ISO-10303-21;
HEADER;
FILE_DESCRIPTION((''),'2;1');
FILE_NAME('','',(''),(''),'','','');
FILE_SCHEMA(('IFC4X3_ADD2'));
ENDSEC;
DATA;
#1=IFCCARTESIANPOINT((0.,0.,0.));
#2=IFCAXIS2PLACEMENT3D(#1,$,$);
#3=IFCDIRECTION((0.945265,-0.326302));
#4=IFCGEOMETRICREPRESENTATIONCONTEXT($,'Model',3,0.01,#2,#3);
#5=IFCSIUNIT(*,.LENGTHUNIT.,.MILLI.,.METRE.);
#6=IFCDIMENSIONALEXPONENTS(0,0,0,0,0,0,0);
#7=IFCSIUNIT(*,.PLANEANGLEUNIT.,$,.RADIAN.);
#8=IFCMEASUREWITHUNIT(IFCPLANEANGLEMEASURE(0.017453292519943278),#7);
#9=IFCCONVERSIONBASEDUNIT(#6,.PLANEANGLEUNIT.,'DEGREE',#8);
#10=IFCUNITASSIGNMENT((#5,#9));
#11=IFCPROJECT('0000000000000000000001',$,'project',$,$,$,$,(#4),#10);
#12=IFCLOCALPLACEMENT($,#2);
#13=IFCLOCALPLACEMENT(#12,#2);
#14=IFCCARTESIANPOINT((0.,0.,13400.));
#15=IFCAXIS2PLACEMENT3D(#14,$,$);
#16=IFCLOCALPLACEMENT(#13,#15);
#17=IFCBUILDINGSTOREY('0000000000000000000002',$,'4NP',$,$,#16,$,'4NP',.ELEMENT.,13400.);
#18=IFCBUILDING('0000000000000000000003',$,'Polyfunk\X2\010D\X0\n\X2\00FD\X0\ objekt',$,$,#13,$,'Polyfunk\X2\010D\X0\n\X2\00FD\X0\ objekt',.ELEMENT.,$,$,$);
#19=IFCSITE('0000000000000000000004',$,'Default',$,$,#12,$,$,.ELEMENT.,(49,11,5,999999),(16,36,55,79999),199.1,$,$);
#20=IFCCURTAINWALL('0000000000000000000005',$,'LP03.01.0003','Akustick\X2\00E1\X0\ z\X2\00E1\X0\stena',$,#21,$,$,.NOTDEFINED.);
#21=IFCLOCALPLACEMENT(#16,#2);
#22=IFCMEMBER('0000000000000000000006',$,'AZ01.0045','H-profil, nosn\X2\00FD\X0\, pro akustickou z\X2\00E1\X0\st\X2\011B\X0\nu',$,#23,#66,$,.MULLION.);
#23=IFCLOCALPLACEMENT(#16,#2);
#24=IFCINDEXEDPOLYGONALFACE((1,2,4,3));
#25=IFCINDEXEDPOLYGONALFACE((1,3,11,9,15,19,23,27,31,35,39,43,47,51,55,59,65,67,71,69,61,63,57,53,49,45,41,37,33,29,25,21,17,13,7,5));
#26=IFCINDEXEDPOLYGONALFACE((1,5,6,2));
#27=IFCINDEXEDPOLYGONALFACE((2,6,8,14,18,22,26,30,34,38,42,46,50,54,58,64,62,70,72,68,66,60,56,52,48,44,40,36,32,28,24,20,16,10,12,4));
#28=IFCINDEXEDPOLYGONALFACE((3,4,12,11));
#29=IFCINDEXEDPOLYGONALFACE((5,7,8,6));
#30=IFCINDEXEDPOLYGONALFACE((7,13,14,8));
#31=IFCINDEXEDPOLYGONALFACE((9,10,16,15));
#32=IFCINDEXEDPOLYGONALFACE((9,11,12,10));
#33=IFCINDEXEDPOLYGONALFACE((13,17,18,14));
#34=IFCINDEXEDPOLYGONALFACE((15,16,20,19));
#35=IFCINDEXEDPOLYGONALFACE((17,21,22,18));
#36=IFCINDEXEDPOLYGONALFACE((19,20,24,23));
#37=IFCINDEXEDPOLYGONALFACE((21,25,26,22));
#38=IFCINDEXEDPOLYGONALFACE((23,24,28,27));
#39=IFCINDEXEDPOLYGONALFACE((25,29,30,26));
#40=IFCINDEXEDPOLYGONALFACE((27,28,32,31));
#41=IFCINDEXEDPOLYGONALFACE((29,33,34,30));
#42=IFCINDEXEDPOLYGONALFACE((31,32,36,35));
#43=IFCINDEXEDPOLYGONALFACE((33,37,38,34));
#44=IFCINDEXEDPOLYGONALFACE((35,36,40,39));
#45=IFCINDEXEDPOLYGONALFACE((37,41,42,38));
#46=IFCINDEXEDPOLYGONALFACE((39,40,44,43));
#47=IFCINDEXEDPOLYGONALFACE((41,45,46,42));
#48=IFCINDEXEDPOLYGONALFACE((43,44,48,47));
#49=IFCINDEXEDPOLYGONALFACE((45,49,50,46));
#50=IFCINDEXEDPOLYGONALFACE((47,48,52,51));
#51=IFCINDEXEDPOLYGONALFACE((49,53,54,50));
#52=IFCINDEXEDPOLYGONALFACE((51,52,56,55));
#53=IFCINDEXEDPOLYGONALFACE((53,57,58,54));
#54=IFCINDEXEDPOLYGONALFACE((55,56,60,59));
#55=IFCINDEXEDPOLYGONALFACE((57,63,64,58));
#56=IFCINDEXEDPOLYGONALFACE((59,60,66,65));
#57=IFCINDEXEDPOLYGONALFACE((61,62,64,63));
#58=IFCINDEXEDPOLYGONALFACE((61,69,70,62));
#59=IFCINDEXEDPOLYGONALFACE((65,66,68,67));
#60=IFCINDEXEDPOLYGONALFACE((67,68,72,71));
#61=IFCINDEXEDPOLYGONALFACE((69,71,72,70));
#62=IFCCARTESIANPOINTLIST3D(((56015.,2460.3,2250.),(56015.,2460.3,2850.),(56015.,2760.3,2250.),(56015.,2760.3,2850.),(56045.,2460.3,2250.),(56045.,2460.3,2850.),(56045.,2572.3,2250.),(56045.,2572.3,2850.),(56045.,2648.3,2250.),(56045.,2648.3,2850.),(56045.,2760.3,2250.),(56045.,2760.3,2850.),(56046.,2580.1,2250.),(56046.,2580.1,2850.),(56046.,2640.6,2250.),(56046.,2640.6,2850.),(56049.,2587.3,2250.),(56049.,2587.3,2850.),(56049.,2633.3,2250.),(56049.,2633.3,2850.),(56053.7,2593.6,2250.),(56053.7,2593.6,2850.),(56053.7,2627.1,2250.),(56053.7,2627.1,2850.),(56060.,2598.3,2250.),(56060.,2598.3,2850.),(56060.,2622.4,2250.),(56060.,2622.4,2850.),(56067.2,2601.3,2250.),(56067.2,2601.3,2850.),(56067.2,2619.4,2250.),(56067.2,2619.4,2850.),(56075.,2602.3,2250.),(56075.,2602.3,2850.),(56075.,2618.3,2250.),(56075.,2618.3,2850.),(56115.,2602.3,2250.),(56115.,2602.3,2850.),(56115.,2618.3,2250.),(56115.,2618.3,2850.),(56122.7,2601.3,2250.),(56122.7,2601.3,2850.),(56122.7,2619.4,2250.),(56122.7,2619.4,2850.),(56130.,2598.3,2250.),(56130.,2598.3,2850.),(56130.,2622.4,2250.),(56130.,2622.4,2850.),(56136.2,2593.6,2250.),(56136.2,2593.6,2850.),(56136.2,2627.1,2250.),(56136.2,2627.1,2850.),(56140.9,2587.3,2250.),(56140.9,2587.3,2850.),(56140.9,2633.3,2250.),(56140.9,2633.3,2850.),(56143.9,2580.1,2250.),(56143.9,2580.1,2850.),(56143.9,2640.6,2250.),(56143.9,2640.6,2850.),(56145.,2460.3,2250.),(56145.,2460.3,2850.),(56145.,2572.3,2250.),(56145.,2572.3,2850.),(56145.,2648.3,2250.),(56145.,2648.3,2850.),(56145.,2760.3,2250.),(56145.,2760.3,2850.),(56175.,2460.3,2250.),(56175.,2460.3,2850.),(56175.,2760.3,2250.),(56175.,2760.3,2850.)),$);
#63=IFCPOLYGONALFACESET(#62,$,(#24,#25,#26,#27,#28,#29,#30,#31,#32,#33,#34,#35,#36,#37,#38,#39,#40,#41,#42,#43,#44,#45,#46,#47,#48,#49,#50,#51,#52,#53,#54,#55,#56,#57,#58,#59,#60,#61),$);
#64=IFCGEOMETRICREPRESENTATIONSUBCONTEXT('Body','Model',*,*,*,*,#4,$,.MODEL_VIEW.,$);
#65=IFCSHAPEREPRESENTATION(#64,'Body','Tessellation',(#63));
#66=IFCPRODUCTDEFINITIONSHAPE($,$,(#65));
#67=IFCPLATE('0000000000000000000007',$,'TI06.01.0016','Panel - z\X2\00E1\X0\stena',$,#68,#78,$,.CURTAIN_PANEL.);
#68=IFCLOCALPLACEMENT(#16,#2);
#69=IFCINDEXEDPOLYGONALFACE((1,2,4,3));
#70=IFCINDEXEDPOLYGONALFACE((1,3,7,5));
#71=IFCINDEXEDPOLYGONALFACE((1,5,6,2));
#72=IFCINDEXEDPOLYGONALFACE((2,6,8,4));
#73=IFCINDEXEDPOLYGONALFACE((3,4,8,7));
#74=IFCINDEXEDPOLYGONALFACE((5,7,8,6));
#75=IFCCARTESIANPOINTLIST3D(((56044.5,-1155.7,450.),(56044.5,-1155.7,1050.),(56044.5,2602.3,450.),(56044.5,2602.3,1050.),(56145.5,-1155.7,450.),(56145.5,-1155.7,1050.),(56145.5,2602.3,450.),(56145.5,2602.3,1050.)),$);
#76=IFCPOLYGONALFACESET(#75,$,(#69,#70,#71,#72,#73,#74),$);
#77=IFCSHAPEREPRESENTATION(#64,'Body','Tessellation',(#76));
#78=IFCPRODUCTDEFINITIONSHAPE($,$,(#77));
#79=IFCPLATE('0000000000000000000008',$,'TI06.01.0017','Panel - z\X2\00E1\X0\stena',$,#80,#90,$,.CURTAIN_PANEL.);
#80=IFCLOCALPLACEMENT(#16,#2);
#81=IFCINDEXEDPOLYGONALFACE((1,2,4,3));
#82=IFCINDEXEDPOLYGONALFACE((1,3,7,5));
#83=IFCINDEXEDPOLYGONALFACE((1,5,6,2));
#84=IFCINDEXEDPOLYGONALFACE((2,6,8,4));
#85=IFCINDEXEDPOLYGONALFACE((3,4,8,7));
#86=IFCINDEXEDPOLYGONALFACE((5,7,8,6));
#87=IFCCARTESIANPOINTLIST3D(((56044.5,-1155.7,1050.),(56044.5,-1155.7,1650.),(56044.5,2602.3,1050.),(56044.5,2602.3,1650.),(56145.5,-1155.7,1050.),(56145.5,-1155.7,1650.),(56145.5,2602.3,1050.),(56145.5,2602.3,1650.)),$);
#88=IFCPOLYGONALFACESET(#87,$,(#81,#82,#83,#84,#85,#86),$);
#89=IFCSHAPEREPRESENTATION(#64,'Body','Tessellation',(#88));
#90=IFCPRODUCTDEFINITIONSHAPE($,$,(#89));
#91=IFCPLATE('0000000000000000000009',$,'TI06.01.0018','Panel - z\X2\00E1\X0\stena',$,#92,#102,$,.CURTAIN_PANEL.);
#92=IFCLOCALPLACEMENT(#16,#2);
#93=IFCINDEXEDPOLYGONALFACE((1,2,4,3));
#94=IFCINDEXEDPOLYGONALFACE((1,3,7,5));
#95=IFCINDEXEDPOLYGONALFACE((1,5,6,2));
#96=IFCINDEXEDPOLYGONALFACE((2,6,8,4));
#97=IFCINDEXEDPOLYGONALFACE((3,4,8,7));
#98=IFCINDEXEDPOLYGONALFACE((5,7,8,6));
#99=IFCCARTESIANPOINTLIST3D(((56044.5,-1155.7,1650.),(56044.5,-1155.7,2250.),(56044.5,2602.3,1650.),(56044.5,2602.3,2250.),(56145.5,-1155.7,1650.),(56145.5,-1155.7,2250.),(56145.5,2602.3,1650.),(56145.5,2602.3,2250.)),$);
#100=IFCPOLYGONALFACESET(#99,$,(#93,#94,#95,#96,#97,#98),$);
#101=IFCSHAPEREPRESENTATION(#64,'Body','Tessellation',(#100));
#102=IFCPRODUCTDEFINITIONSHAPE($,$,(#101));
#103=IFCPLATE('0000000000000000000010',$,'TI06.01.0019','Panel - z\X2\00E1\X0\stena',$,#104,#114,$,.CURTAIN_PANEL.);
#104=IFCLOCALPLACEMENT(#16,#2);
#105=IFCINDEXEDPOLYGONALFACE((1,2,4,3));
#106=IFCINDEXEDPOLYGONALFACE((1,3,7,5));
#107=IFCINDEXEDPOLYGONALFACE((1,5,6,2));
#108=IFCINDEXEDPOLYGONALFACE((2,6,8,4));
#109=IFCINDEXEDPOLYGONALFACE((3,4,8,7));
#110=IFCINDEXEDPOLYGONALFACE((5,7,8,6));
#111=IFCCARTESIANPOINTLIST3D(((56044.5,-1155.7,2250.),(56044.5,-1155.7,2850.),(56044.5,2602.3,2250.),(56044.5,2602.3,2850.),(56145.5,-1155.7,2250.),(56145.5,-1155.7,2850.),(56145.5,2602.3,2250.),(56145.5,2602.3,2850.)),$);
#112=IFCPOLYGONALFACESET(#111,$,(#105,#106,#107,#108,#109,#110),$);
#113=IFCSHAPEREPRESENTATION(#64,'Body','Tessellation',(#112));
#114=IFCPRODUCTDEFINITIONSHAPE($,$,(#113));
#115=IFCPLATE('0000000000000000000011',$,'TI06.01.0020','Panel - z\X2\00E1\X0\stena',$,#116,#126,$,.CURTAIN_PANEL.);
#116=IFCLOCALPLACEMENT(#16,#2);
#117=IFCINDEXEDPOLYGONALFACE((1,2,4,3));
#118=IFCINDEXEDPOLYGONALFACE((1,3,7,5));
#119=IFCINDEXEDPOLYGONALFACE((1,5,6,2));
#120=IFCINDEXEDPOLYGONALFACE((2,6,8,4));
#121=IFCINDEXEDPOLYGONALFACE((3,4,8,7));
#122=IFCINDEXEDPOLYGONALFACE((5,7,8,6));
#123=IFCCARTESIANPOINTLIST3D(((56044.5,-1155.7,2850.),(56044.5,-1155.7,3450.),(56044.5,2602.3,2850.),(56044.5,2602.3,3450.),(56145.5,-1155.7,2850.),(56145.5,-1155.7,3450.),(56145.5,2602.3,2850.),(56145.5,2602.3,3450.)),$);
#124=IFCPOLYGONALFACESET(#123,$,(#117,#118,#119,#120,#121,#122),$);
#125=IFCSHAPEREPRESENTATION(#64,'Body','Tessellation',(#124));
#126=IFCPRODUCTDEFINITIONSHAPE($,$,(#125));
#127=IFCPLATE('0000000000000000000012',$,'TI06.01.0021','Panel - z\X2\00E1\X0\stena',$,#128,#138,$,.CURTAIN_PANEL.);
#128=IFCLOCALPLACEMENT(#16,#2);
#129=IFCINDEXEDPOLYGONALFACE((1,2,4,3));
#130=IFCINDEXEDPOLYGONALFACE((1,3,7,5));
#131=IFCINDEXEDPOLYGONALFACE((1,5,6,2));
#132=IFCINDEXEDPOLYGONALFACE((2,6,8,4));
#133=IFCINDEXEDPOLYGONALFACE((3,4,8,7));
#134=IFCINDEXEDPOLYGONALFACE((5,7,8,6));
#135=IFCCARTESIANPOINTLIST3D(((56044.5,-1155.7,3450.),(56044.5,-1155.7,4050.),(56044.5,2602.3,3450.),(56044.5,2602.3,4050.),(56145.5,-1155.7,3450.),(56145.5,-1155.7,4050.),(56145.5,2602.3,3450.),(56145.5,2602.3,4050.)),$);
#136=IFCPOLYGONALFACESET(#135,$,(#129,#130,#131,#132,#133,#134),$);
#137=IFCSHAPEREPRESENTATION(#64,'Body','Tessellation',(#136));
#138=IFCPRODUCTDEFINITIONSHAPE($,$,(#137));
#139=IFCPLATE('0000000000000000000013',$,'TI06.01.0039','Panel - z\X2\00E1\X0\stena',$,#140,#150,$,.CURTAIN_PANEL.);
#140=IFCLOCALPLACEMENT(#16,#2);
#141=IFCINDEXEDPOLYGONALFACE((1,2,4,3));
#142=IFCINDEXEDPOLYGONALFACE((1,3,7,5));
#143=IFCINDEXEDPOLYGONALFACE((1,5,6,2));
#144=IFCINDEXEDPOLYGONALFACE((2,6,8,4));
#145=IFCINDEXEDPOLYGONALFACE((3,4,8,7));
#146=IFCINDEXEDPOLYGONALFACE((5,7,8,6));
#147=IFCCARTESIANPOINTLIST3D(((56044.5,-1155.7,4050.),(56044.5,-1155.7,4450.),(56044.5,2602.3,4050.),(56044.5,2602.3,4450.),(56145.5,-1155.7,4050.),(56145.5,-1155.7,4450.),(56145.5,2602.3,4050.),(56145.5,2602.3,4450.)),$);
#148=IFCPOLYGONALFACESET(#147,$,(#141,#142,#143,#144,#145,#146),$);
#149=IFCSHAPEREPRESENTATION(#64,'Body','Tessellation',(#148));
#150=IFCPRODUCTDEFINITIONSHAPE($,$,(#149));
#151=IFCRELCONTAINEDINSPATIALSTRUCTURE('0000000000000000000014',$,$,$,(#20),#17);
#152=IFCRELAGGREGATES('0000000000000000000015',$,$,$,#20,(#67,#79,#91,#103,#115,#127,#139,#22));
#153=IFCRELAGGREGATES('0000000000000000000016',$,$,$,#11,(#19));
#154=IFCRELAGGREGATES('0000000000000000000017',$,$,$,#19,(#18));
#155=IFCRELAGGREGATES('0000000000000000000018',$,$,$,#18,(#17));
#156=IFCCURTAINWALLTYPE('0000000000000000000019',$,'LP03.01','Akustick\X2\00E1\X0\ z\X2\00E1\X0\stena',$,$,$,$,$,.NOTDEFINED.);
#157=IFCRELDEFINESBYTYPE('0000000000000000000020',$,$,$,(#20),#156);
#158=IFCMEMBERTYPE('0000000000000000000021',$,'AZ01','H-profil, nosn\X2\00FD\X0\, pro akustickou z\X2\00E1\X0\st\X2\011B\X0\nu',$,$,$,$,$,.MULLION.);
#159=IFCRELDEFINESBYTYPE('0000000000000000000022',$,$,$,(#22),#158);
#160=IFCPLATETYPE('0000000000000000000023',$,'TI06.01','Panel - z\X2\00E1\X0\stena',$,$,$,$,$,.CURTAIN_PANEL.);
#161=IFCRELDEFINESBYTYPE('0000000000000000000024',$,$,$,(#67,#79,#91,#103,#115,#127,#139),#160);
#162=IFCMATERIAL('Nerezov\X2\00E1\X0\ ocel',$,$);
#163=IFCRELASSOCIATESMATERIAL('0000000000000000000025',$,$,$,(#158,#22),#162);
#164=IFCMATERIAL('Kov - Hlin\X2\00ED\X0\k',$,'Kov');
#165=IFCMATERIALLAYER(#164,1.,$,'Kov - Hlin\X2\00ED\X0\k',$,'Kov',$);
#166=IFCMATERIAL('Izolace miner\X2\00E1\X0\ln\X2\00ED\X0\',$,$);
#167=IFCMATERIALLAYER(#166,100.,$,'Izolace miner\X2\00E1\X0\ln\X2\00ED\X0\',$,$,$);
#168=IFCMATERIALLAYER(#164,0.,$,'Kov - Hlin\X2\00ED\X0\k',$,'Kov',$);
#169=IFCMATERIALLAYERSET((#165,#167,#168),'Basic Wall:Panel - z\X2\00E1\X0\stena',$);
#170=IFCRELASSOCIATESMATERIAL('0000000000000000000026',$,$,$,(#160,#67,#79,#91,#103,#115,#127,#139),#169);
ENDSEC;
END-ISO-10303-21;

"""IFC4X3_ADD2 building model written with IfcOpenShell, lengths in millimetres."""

from ifc_helpers import new_model, entity, si_unit, converted_unit, direction, frame, frame_2d, origin, place, context, subcontext, project, spatial, polyline, circle_curve, parameter, trimmed, segment, composite_curve, rectangle, outline, extrude, source, transform, mapped, material, layer, layer_set, layer_usage, material_profile, profile_set, profile_usage, type_object, element, aggregate, save


model = new_model("IFC4X3_ADD2")

# Units and contexts
model_context = context("Model", 3, precision=0.01, world=origin(), true_north=direction((0.945265, -0.326302)))
body_context = subcontext(model_context, "Body", "Model", "MODEL_VIEW")
ifc_project = project(units=[si_unit("LENGTHUNIT", "METRE", prefix="MILLI"), converted_unit("PLANEANGLEUNIT", "DEGREE", entity("IfcPlaneAngleMeasure", 0.017453292519943278), si_unit("PLANEANGLEUNIT", "RADIAN"), dimensions=[0, 0, 0, 0, 0, 0, 0])], contexts=[model_context])

# Site, building, storey
site_placement = place(None, origin())
site = spatial("IfcSite", under=ifc_project, at=site_placement, Name="Default", CompositionType="ELEMENT", RefLatitude=(49, 11, 5, 999999), RefLongitude=(16, 36, 55, 79999), RefElevation=199.1)
building_placement = place(site_placement, origin())
building = spatial("IfcBuilding", under=site, at=building_placement, Name="Polyfunkčný objekt", LongName="Polyfunkčný objekt", CompositionType="ELEMENT")
storey_placement = place(building_placement, frame((0.0, 0.0, 13400.0)))
storey = spatial("IfcBuildingStorey", under=building, at=storey_placement, Name="4NP", LongName="4NP", CompositionType="ELEMENT", Elevation=13400.0)

# Curtain wall, member, plates
curtain_wall_type = type_object("IfcCurtainWallType", Name="LP03.01", Description="Akustická zástena", PredefinedType="NOTDEFINED")
curtain_wall_placement = place(storey_placement, frame((0.0, 0.0, -13400.0)))
curtain_wall = element("IfcCurtainWall", 1, at=curtain_wall_placement, inside=storey, type_object=curtain_wall_type, Name="LP03.01.0003", Description="Akustická zástena", PredefinedType="NOTDEFINED")
ifc_material_1 = material(Name="Nerezová ocel")
ifc_material_profile = material_profile(ifc_material_1, outline(composite_curve([segment(polyline([(50.0, -150.0), (80.0, -150.0)]), True, "CONTINUOUS"), segment(polyline([(80.0, -150.0), (80.0, 150.0)]), True, "CONTINUOUS"), segment(polyline([(80.0, 150.0), (50.0, 150.0)]), True, "CONTINUOUS"), segment(polyline([(50.0, 150.0), (50.0, 38.0)]), True, "CONTINUOUS"), segment(trimmed(circle_curve(frame_2d((20.0, 38.0), x_axis=(0.0, 1.0)), 30.0), [parameter(180.0)], [parameter(270.0)], True, "PARAMETER"), False, "CONTINUOUS"), segment(polyline([(20.0, 8.0), (-20.0, 8.0)]), True, "CONTINUOUS"), segment(trimmed(circle_curve(frame_2d((-20.0, 38.0), x_axis=(0.0, 1.0)), 30.0), [parameter(90.0)], [parameter(180.0)], True, "PARAMETER"), False, "CONTINUOUS"), segment(polyline([(-50.0, 38.0), (-50.0, 150.0)]), True, "CONTINUOUS"), segment(polyline([(-50.0, 150.0), (-80.0, 150.0)]), True, "CONTINUOUS"), segment(polyline([(-80.0, 150.0), (-80.0, -150.0)]), True, "CONTINUOUS"), segment(polyline([(-80.0, -150.0), (-50.0, -150.0)]), True, "CONTINUOUS"), segment(polyline([(-50.0, -150.0), (-50.0, -38.0)]), True, "CONTINUOUS"), segment(trimmed(circle_curve(frame_2d((-20.0, -38.0), x_axis=(0.0, 1.0)), 30.0), [parameter(0.0)], [parameter(90.0)], True, "PARAMETER"), False, "CONTINUOUS"), segment(polyline([(-20.0, -8.0), (20.0, -8.0)]), True, "CONTINUOUS"), segment(trimmed(circle_curve(frame_2d((20.0, -38.0), x_axis=(0.0, 1.0)), 30.0), [parameter(270.0)], [parameter(0.0)], True, "PARAMETER"), False, "CONTINUOUS"), segment(polyline([(50.0, -38.0), (50.0, -150.0)]), True, "CONTINUOUS")], self_intersect=False)), Name="Profil zástena")
ifc_profile_set = profile_set([ifc_material_profile], Name="Profil zástena")
ifc_profile_usage = profile_usage(ifc_profile_set)
member_type = type_object("IfcMemberType", Name="AZ01", Description="H-profil, nosný, pro akustickou zástěnu", PredefinedType="MULLION", material=ifc_profile_set)
shared_shape_1 = source(origin(), body_context, "Body", "SweptSolid", [
    extrude(outline(composite_curve([segment(polyline([(-150.0, -50.0), (-150.0, -80.0)]), True, "CONTINUOUS"), segment(polyline([(-150.0, -80.0), (150.0, -80.0)]), True, "CONTINUOUS"), segment(polyline([(150.0, -80.0), (150.0, -50.0)]), True, "CONTINUOUS"), segment(polyline([(150.0, -50.0), (38.0, -50.0)]), True, "CONTINUOUS"), segment(trimmed(circle_curve(frame_2d((38.0, -20.0), x_axis=(1.0, 0.0)), 30.0), [parameter(180.0)], [parameter(270.0)], True, "PARAMETER"), False, "CONTINUOUS"), segment(polyline([(8.0, -20.0), (8.0, 20.0)]), True, "CONTINUOUS"), segment(trimmed(circle_curve(frame_2d((38.0, 20.0), x_axis=(1.0, 0.0)), 30.0), [parameter(90.0)], [parameter(180.0)], True, "PARAMETER"), False, "CONTINUOUS"), segment(polyline([(38.0, 50.0), (150.0, 50.0)]), True, "CONTINUOUS"), segment(polyline([(150.0, 50.0), (150.0, 80.0)]), True, "CONTINUOUS"), segment(polyline([(150.0, 80.0), (-150.0, 80.0)]), True, "CONTINUOUS"), segment(polyline([(-150.0, 80.0), (-150.0, 50.0)]), True, "CONTINUOUS"), segment(polyline([(-150.0, 50.0), (-38.0, 50.0)]), True, "CONTINUOUS"), segment(trimmed(circle_curve(frame_2d((-38.0, 20.0), x_axis=(1.0, 0.0)), 30.0), [parameter(0.0)], [parameter(90.0)], True, "PARAMETER"), False, "CONTINUOUS"), segment(polyline([(-8.0, 20.0), (-8.0, -20.0)]), True, "CONTINUOUS"), segment(trimmed(circle_curve(frame_2d((-38.0, -20.0), x_axis=(1.0, 0.0)), 30.0), [parameter(270.0)], [parameter(0.0)], True, "PARAMETER"), False, "CONTINUOUS"), segment(polyline([(-38.0, -50.0), (-150.0, -50.0)]), True, "CONTINUOUS")], self_intersect=False)), frame((0.0, 0.0, -600.0), z_axis=(0.0, 0.0, -1.0), x_axis=(1.0, 0.0, 0.0)), (0.0, 0.0, -1.0), 600.0),
])
member_1_placement = place(curtain_wall_placement, frame((56095.0, 2610.3, 15650.0), z_axis=(0.0, 0.0, -1.0), x_axis=(0.0, 1.0, 0.0)))
member_1 = element("IfcMember", 2, at=member_1_placement, type_object=member_type, material=ifc_profile_usage, Name="AZ01.0045", Description="H-profil, nosný, pro akustickou zástěnu", PredefinedType="MULLION", context=body_context, shape_type="MappedRepresentation", body=[
    mapped(shared_shape_1, transform((0.0, 0.0, 0.0), scale=1.0)),
])
ifc_material_2 = material(Name="Kov - Hliník", Category="Kov")
ifc_layer_1 = layer(ifc_material_2, 1.0, Name="Kov - Hliník", Category="Kov")
ifc_material_3 = material(Name="Izolace minerální")
ifc_layer_2 = layer(ifc_material_3, 100.0, Name="Izolace minerální")
ifc_layer_3 = layer(ifc_material_2, 0.0, Name="Kov - Hliník", Category="Kov")
ifc_layer_set_1 = layer_set([ifc_layer_1, ifc_layer_2, ifc_layer_3], Name="Basic Wall:Panel - zástena")
ifc_layer_usage_1 = layer_usage(ifc_layer_set_1, "AXIS2", "NEGATIVE", 50.5)
plate_type = type_object("IfcPlateType", Name="TI06.01", Description="Panel - zástena", PredefinedType="CURTAIN_PANEL", material=ifc_layer_set_1)
plate_1_placement = place(storey_placement, frame((56095.0, -1155.7, 450.0), z_axis=(0.0, 0.0, 1.0), x_axis=(0.0, 1.0, 0.0)))
plate_1 = element("IfcPlate", 3, at=plate_1_placement, type_object=plate_type, material=ifc_layer_usage_1, Name="TI06.01.0016", Description="Panel - zástena", PredefinedType="CURTAIN_PANEL", context=body_context, shape_type="SweptSolid", body=[
    extrude(rectangle(XDim=101.0, YDim=3758.1, at=frame_2d((0.0, 0.0), x_axis=(1.0, 0.0))), frame((1879.0, 0.0, 0.0), z_axis=(0.0, 0.0, 1.0), x_axis=(0.0, 1.0, 0.0)), (0.0, 0.0, 1.0), 600.0),
])
ifc_layer_usage_2 = layer_usage(ifc_layer_set_1, "AXIS2", "NEGATIVE", 50.5)
plate_2_placement = place(storey_placement, frame((56095.0, -1155.7, 1050.0), z_axis=(0.0, 0.0, 1.0), x_axis=(0.0, 1.0, 0.0)))
plate_2 = element("IfcPlate", 4, at=plate_2_placement, type_object=plate_type, material=ifc_layer_usage_2, Name="TI06.01.0017", Description="Panel - zástena", PredefinedType="CURTAIN_PANEL", context=body_context, shape_type="SweptSolid", body=[
    extrude(rectangle(XDim=101.0, YDim=3758.1, at=frame_2d((0.0, 0.0), x_axis=(1.0, 0.0))), frame((1879.0, 0.0, 0.0), z_axis=(0.0, 0.0, 1.0), x_axis=(0.0, 1.0, 0.0)), (0.0, 0.0, 1.0), 600.0),
])
ifc_layer_usage_3 = layer_usage(ifc_layer_set_1, "AXIS2", "NEGATIVE", 50.5)
plate_3_placement = place(storey_placement, frame((56095.0, -1155.7, 1650.0), z_axis=(0.0, 0.0, 1.0), x_axis=(0.0, 1.0, 0.0)))
plate_3 = element("IfcPlate", 5, at=plate_3_placement, type_object=plate_type, material=ifc_layer_usage_3, Name="TI06.01.0018", Description="Panel - zástena", PredefinedType="CURTAIN_PANEL", context=body_context, shape_type="SweptSolid", body=[
    extrude(rectangle(XDim=101.0, YDim=3758.1, at=frame_2d((0.0, 0.0), x_axis=(1.0, 0.0))), frame((1879.0, 0.0, 0.0), z_axis=(0.0, 0.0, 1.0), x_axis=(0.0, 1.0, 0.0)), (0.0, 0.0, 1.0), 600.0),
])
ifc_layer_usage_4 = layer_usage(ifc_layer_set_1, "AXIS2", "NEGATIVE", 50.5)
plate_4_placement = place(storey_placement, frame((56095.0, -1155.7, 2250.0), z_axis=(0.0, 0.0, 1.0), x_axis=(0.0, 1.0, 0.0)))
plate_4 = element("IfcPlate", 6, at=plate_4_placement, type_object=plate_type, material=ifc_layer_usage_4, Name="TI06.01.0019", Description="Panel - zástena", PredefinedType="CURTAIN_PANEL", context=body_context, shape_type="SweptSolid", body=[
    extrude(rectangle(XDim=101.0, YDim=3758.1, at=frame_2d((0.0, 0.0), x_axis=(1.0, 0.0))), frame((1879.0, 0.0, 0.0), z_axis=(0.0, 0.0, 1.0), x_axis=(0.0, 1.0, 0.0)), (0.0, 0.0, 1.0), 600.0),
])
ifc_layer_usage_5 = layer_usage(ifc_layer_set_1, "AXIS2", "NEGATIVE", 50.5)
plate_5_placement = place(storey_placement, frame((56095.0, -1155.7, 2850.0), z_axis=(0.0, 0.0, 1.0), x_axis=(0.0, 1.0, 0.0)))
plate_5 = element("IfcPlate", 7, at=plate_5_placement, type_object=plate_type, material=ifc_layer_usage_5, Name="TI06.01.0020", Description="Panel - zástena", PredefinedType="CURTAIN_PANEL", context=body_context, shape_type="SweptSolid", body=[
    extrude(rectangle(XDim=101.0, YDim=3758.1, at=frame_2d((0.0, 0.0), x_axis=(1.0, 0.0))), frame((1879.0, 0.0, 0.0), z_axis=(0.0, 0.0, 1.0), x_axis=(0.0, 1.0, 0.0)), (0.0, 0.0, 1.0), 600.0),
])
ifc_layer_usage_6 = layer_usage(ifc_layer_set_1, "AXIS2", "NEGATIVE", 50.5)
plate_6_placement = place(storey_placement, frame((56095.0, -1155.7, 3450.0), z_axis=(0.0, 0.0, 1.0), x_axis=(0.0, 1.0, 0.0)))
plate_6 = element("IfcPlate", 8, at=plate_6_placement, type_object=plate_type, material=ifc_layer_usage_6, Name="TI06.01.0021", Description="Panel - zástena", PredefinedType="CURTAIN_PANEL", context=body_context, shape_type="SweptSolid", body=[
    extrude(rectangle(XDim=101.0, YDim=3758.1, at=frame_2d((0.0, 0.0), x_axis=(1.0, 0.0))), frame((1879.0, 0.0, 0.0), z_axis=(0.0, 0.0, 1.0), x_axis=(0.0, 1.0, 0.0)), (0.0, 0.0, 1.0), 600.0),
])
ifc_layer_usage_7 = layer_usage(ifc_layer_set_1, "AXIS2", "NEGATIVE", 50.5)
plate_7_placement = place(storey_placement, frame((56095.0, -1155.7, 4050.0), z_axis=(0.0, 0.0, 1.0), x_axis=(0.0, 1.0, 0.0)))
plate_7 = element("IfcPlate", 9, at=plate_7_placement, type_object=plate_type, material=ifc_layer_usage_7, Name="TI06.01.0039", Description="Panel - zástena", PredefinedType="CURTAIN_PANEL", context=body_context, shape_type="SweptSolid", body=[
    extrude(rectangle(XDim=101.0, YDim=3758.1, at=frame_2d((0.0, 0.0), x_axis=(1.0, 0.0))), frame((1879.0, 0.0, 0.0), z_axis=(0.0, 0.0, 1.0), x_axis=(0.0, 1.0, 0.0)), (0.0, 0.0, 1.0), 400.0),
])
aggregate(curtain_wall, [plate_1, plate_2, plate_3, plate_4, plate_5, plate_6, plate_7, member_1])

save(model, "model.ifc")
